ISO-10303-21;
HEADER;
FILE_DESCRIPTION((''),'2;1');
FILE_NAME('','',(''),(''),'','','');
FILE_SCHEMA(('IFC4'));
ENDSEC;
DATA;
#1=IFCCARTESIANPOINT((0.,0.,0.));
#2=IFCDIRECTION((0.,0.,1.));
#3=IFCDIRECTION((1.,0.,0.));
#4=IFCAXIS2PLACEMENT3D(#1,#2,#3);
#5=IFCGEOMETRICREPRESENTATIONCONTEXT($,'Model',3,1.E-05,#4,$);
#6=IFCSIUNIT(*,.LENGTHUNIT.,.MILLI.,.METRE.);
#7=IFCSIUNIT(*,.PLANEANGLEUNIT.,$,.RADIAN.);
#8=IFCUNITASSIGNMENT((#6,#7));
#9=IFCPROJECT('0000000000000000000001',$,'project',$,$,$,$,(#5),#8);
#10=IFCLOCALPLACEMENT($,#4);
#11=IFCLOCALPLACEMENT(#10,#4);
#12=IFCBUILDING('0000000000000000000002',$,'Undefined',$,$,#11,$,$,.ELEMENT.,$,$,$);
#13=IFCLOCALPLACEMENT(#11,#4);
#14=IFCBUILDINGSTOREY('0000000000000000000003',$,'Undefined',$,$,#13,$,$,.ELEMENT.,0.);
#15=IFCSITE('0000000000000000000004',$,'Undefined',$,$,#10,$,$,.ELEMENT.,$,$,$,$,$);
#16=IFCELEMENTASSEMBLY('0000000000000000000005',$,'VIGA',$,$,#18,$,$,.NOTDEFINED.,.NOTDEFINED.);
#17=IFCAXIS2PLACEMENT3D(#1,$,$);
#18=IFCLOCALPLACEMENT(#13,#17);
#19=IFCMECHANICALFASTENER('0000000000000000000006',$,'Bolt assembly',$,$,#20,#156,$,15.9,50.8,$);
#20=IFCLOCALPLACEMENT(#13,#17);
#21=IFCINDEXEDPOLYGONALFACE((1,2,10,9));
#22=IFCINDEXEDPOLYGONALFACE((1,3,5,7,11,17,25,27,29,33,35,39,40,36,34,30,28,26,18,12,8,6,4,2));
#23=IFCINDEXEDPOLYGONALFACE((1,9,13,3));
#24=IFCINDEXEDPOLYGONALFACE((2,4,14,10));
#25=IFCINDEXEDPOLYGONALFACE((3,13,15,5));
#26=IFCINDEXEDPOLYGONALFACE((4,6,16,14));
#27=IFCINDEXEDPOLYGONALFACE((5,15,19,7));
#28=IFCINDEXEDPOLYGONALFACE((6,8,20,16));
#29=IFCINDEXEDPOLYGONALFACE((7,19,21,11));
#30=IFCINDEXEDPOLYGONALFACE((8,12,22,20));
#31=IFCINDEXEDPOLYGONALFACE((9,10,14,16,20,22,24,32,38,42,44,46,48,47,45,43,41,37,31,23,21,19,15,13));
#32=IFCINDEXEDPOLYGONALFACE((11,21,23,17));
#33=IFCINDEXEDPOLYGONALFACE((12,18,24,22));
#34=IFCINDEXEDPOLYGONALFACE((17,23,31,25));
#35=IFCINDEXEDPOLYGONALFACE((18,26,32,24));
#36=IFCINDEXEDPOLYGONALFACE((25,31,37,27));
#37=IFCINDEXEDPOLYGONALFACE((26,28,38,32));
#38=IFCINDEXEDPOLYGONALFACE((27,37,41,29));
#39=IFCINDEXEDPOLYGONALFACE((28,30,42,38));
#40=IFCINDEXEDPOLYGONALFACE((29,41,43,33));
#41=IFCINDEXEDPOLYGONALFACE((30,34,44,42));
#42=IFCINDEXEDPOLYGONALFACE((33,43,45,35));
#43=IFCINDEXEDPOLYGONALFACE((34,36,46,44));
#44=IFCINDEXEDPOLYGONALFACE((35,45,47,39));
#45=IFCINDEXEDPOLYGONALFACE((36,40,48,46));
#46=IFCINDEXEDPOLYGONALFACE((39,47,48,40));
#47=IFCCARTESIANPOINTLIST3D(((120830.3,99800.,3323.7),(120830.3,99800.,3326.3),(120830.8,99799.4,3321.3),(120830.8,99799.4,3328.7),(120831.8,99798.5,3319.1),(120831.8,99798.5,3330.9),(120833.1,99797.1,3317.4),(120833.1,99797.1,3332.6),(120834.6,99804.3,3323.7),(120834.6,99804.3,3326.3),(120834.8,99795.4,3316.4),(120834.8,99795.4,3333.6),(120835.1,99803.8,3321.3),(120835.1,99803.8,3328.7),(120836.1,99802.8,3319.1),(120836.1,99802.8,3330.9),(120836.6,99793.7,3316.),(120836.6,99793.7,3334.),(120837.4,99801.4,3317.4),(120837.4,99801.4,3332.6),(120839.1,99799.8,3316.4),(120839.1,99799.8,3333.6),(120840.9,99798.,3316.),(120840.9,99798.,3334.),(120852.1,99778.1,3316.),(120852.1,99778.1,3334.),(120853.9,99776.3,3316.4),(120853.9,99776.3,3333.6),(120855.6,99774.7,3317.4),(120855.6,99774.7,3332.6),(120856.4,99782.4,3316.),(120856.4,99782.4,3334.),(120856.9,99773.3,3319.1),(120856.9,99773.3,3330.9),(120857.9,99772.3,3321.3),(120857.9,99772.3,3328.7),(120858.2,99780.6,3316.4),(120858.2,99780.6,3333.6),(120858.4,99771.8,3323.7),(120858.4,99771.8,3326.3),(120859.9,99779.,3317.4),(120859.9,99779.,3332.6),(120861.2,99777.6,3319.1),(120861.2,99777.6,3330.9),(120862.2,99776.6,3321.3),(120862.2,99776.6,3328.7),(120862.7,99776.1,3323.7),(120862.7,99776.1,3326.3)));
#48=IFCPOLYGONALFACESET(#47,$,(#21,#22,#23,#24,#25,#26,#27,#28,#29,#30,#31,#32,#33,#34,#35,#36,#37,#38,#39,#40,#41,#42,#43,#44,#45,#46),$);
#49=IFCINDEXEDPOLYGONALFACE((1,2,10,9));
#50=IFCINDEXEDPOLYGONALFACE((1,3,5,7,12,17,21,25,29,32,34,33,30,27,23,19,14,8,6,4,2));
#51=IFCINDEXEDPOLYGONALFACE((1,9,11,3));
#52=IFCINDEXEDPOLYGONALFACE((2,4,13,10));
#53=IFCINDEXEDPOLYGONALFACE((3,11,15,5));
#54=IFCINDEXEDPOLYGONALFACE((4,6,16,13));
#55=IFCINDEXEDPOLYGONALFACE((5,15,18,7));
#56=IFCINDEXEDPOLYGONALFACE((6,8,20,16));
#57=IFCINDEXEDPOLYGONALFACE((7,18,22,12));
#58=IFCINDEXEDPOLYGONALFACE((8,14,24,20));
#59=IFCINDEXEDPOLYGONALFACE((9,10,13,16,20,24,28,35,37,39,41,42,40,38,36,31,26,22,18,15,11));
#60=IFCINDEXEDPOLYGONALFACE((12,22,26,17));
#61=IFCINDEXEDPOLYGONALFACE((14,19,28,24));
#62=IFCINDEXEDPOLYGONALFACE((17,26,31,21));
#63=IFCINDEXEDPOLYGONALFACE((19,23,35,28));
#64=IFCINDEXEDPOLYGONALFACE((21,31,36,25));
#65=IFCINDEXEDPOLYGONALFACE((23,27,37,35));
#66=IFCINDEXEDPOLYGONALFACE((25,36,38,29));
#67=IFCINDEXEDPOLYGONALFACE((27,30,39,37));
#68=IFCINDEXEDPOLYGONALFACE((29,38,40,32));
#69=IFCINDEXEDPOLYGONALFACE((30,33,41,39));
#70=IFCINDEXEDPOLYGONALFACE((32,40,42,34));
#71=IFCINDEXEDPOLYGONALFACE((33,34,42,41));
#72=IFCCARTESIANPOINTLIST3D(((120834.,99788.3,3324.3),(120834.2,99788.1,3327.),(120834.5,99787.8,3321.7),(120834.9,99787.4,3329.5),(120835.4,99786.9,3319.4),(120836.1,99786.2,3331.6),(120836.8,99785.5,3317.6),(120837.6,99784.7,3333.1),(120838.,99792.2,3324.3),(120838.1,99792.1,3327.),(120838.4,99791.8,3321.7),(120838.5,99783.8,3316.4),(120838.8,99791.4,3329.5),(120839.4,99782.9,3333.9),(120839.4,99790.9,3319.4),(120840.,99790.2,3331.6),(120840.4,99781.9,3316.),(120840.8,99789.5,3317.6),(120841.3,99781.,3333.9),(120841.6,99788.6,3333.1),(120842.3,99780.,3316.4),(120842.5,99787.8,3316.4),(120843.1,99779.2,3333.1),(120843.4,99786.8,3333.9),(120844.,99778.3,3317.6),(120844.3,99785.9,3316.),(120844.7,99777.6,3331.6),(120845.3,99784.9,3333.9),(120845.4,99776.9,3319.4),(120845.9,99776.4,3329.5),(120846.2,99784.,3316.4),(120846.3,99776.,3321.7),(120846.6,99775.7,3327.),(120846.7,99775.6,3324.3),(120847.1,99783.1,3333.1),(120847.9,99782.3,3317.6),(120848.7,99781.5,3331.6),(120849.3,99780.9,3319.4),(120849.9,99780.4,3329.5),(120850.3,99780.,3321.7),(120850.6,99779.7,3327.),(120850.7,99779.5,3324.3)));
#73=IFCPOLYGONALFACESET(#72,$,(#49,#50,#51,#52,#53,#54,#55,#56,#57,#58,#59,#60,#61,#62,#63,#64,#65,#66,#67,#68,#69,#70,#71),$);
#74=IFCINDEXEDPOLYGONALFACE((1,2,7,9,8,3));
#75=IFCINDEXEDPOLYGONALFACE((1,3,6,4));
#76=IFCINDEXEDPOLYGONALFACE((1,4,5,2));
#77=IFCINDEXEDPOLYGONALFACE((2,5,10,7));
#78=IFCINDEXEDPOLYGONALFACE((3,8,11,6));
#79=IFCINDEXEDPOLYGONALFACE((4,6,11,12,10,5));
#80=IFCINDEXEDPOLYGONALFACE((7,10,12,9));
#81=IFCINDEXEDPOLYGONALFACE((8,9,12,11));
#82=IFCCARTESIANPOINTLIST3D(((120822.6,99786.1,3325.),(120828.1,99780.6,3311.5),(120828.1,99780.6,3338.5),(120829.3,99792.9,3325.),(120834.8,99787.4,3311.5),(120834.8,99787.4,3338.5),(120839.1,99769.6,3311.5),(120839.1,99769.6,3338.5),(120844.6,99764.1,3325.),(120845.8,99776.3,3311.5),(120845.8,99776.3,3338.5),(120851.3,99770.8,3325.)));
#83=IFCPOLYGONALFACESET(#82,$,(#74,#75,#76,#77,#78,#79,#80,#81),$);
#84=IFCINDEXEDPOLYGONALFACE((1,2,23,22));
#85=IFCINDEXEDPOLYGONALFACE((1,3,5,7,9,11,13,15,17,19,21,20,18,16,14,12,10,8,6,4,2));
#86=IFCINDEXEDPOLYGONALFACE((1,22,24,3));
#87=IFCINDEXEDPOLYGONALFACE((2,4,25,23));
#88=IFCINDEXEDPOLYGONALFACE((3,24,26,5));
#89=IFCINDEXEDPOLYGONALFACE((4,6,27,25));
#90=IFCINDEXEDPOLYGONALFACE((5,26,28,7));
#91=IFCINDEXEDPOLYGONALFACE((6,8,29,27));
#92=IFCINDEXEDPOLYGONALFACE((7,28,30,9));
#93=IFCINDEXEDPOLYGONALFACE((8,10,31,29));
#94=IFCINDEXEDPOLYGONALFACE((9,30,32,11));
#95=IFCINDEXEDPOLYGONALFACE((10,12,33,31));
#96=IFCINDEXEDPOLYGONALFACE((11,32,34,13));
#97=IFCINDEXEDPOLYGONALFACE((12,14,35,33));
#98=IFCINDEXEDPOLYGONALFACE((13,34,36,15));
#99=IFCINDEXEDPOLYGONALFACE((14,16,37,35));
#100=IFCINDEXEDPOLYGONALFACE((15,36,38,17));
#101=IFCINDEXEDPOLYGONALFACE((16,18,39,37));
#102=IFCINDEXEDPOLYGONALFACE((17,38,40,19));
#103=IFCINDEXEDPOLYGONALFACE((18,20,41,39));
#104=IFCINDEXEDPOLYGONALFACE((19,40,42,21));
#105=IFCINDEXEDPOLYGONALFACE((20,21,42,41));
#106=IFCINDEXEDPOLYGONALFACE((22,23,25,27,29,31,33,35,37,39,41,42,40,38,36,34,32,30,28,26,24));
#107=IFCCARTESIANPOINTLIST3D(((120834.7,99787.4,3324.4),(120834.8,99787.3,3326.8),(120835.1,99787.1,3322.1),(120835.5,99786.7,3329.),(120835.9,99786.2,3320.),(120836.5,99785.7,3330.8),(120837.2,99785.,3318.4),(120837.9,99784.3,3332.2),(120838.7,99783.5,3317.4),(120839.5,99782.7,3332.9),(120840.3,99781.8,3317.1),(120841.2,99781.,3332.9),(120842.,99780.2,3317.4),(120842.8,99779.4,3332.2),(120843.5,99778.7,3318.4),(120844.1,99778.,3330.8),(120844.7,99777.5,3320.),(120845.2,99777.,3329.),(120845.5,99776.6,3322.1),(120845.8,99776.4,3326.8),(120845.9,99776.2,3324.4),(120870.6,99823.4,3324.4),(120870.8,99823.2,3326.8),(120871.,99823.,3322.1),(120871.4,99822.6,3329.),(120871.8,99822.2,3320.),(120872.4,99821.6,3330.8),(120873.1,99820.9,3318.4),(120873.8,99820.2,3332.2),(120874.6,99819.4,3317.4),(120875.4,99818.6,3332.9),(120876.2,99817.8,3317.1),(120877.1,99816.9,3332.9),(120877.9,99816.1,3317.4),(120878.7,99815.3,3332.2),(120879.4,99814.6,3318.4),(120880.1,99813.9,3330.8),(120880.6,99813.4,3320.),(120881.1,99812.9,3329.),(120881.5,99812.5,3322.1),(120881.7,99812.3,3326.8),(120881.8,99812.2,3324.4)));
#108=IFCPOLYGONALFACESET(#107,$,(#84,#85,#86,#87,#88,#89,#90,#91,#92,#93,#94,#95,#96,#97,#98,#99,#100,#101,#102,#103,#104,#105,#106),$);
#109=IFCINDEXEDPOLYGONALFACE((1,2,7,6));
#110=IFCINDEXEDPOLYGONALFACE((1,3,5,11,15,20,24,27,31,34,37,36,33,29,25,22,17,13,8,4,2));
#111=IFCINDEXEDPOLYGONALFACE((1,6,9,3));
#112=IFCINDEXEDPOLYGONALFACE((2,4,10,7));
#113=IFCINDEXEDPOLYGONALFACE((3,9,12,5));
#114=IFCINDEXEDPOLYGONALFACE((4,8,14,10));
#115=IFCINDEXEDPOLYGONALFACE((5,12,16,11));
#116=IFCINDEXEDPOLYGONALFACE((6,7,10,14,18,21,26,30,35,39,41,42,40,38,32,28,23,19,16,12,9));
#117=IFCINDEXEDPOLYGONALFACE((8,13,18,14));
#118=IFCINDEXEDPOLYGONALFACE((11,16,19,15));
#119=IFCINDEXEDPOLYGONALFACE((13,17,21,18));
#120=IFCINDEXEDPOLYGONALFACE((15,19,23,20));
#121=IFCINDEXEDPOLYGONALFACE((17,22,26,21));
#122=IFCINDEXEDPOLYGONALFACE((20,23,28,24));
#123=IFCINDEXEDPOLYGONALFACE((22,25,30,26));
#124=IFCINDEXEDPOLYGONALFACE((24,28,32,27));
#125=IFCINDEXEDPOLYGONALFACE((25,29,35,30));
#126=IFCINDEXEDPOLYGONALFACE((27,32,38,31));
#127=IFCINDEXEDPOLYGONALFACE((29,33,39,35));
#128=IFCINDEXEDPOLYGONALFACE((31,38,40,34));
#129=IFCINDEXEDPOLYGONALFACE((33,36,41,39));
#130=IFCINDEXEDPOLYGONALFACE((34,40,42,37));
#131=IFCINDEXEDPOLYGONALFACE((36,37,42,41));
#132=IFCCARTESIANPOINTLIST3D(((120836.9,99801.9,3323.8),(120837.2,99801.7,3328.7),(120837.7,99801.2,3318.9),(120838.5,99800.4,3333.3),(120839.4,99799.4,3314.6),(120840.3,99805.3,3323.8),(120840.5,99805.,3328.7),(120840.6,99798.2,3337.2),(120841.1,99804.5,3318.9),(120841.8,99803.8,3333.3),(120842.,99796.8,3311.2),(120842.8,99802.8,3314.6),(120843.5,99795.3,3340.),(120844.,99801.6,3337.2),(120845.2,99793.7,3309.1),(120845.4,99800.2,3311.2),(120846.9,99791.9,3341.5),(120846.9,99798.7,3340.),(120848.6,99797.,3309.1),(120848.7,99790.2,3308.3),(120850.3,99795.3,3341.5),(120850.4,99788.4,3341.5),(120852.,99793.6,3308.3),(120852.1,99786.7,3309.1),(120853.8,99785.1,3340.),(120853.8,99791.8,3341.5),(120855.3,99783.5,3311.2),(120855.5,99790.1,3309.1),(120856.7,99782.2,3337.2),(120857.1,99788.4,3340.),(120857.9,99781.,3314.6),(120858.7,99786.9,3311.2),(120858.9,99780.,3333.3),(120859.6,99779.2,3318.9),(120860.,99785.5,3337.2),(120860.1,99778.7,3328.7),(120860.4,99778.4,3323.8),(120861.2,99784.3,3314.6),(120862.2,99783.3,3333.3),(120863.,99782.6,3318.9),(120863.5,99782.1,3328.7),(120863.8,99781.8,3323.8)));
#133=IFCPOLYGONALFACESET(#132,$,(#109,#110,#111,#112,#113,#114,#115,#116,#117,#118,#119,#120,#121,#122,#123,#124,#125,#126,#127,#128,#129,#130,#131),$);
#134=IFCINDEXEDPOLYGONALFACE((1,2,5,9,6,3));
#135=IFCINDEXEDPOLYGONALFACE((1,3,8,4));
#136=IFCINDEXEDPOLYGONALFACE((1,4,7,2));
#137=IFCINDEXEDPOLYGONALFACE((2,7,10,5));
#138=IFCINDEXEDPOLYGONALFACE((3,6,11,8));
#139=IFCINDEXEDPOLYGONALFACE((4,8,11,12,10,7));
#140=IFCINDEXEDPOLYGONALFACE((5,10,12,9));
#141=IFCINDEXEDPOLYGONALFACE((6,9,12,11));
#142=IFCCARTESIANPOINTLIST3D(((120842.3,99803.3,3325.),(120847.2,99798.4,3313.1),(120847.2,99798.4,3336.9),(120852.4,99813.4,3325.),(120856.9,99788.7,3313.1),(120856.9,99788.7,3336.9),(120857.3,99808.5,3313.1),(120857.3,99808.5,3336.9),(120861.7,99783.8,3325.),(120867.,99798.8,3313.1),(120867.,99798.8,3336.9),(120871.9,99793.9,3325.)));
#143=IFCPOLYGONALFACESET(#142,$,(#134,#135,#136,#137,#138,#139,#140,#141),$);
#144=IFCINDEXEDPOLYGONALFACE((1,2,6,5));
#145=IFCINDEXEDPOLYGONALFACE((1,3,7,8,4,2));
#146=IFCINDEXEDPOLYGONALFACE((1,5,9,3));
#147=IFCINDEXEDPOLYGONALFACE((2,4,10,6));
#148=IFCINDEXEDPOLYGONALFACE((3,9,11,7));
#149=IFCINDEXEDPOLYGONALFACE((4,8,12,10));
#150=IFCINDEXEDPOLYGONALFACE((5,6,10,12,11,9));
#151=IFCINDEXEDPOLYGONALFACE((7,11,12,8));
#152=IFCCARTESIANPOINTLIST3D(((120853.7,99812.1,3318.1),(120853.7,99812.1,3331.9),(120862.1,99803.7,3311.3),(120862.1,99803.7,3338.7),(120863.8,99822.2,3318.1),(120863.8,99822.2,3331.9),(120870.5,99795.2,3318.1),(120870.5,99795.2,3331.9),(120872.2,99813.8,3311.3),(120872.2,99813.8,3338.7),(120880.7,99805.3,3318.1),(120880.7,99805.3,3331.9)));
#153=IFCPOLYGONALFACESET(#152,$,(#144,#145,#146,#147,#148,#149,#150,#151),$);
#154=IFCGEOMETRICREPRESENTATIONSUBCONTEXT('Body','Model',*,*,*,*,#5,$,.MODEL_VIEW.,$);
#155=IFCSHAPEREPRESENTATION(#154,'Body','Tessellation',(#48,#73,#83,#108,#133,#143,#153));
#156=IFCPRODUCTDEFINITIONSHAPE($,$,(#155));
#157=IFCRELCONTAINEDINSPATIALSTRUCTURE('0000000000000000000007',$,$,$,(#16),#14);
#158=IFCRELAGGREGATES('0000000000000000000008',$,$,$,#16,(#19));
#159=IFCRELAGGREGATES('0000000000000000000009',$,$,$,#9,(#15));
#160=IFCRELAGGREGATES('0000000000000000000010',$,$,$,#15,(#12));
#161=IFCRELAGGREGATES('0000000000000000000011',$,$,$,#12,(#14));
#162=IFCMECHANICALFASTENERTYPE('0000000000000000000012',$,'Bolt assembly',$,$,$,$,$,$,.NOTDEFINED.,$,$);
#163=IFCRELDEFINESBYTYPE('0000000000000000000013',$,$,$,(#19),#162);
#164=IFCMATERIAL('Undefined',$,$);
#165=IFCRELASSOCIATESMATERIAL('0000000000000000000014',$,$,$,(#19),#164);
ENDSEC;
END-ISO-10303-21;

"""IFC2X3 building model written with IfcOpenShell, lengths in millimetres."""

from ifc_helpers import new_model, si_unit, frame, frame_2d, origin_with_axes, origin_2d_with_axis, place, context, subcontext, project, spatial, polyline, circle_curve, parameter, trimmed, segment, composite_curve, circle, outline, extrude, source, transform, mapped, material, type_object, element, aggregate, save


model = new_model("IFC2X3")

# Units and contexts
model_context = context("Model", 3, precision=1e-05, world=origin_with_axes())
body_context = subcontext(model_context, "Body", "Model", "MODEL_VIEW")
ifc_project = project(units=[si_unit("LENGTHUNIT", "METRE", prefix="MILLI"), si_unit("PLANEANGLEUNIT", "RADIAN")], contexts=[model_context])

# Site, building, storey
site_placement = place(None, origin_with_axes())
site = spatial("IfcSite", under=ifc_project, at=site_placement, Name="Undefined", CompositionType="ELEMENT")
building_placement = place(site_placement, origin_with_axes())
building = spatial("IfcBuilding", under=site, at=building_placement, Name="Undefined", CompositionType="ELEMENT")
storey_placement = place(building_placement, origin_with_axes())
storey = spatial("IfcBuildingStorey", under=building, at=storey_placement, Name="Undefined", CompositionType="ELEMENT", Elevation=0.0)

# Element assembly
assembly_1_placement = place(storey_placement, origin_with_axes())
assembly_1 = element("IfcElementAssembly", 1, at=assembly_1_placement, inside=storey, Name="VIGA", AssemblyPlace="NOTDEFINED", PredefinedType="NOTDEFINED")

# Mechanical fastener
ifc_material_1 = material(Name="Undefined")
mechanical_fastener_type = type_object("IfcMechanicalFastenerType", Name="Bolt assembly")
shared_shape_1 = source(origin_with_axes(), body_context, "Body", "SweptSolid", [
    extrude(outline(composite_curve([segment(polyline([(9.0, 11.0), (9.0, -11.0)]), True, "CONTINUOUS"), segment(trimmed(circle_curve(frame_2d((0.0, -11.0), x_axis=(1.0, 0.0)), 9.0), [parameter(0.0)], [parameter(3.141593)], False, "PARAMETER"), True, "CONTINUOUS"), segment(polyline([(-9.0, -11.0), (-9.0, 11.0)]), True, "CONTINUOUS"), segment(trimmed(circle_curve(frame_2d((0.0, 11.0), x_axis=(-1.0, 0.0)), 9.0), [parameter(0.0)], [parameter(3.141593)], False, "PARAMETER"), True, "DISCONTINUOUS")], self_intersect=False)), frame((0.0, 2.9, 0.0), z_axis=(0.0, 1.0, 0.0), x_axis=(1.0, 0.0, 0.0)), (0.0, 0.0, 1.0), 6.1),
    extrude(circle(Radius=9.0, at=origin_2d_with_axis()), frame((0.0, -2.7, 0.0), z_axis=(0.0, 1.0, 0.0), x_axis=(1.0, 0.0, 0.0)), (0.0, 0.0, 1.0), 5.6),
    extrude(outline(polyline([(13.5, -7.8), (13.5, 7.8), (0.0, 15.6), (-13.5, 7.8), (-13.5, -7.8), (0.0, -15.6), (13.5, -7.8)])), frame((0.0, -12.3, 0.0), z_axis=(0.0, 1.0, 0.0), x_axis=(1.0, 0.0, 0.0)), (0.0, 0.0, 1.0), 9.5),
    extrude(circle(Radius=7.9, at=origin_2d_with_axis()), frame((0.0, -2.8, 0.0), z_axis=(0.0, 1.0, 0.0), x_axis=(1.0, 0.0, 0.0)), (0.0, 0.0, 1.0), 50.8),
    extrude(circle(Radius=16.7, at=origin_2d_with_axis()), frame((0.0, 9.0, 0.0), z_axis=(0.0, 1.0, 0.0), x_axis=(1.0, 0.0, 0.0)), (0.0, 0.0, 1.0), 4.8),
    extrude(outline(polyline([(11.9, -6.9), (11.9, 6.9), (0.0, 13.7), (-11.9, 6.9), (-11.9, -6.9), (0.0, -13.7), (11.9, -6.9)])), frame((0.0, 13.8, 0.0), z_axis=(0.0, 1.0, 0.0), x_axis=(1.0, 0.0, 0.0)), (0.0, 0.0, 1.0), 14.3),
    extrude(outline(polyline([(13.7, 0.0), (6.9, 11.9), (-6.9, 11.9), (-13.7, 0.0), (-6.9, -11.9), (6.9, -11.9), (13.7, 0.0)])), frame((0.0, 28.0, 0.0), z_axis=(0.0, 1.0, 0.0), x_axis=(1.0, 0.0, 0.0)), (0.0, 0.0, 1.0), 14.3),
])
mechanical_fastener_1_placement = place(assembly_1_placement, frame((120842.3, 99783.8, 3325.0), z_axis=(0.707107, -0.707106, 0.0), x_axis=(0.0, 0.0, -1.0)))
mechanical_fastener_1 = element("IfcMechanicalFastener", 2, at=mechanical_fastener_1_placement, type_object=mechanical_fastener_type, material=ifc_material_1, Name="Bolt assembly", NominalDiameter=15.9, NominalLength=50.8, context=body_context, shape_type="MappedRepresentation", body=[
    mapped(shared_shape_1, transform((0.0, 0.0, 0.0))),
])
aggregate(assembly_1, [mechanical_fastener_1])

save(model, "model.ifc")
